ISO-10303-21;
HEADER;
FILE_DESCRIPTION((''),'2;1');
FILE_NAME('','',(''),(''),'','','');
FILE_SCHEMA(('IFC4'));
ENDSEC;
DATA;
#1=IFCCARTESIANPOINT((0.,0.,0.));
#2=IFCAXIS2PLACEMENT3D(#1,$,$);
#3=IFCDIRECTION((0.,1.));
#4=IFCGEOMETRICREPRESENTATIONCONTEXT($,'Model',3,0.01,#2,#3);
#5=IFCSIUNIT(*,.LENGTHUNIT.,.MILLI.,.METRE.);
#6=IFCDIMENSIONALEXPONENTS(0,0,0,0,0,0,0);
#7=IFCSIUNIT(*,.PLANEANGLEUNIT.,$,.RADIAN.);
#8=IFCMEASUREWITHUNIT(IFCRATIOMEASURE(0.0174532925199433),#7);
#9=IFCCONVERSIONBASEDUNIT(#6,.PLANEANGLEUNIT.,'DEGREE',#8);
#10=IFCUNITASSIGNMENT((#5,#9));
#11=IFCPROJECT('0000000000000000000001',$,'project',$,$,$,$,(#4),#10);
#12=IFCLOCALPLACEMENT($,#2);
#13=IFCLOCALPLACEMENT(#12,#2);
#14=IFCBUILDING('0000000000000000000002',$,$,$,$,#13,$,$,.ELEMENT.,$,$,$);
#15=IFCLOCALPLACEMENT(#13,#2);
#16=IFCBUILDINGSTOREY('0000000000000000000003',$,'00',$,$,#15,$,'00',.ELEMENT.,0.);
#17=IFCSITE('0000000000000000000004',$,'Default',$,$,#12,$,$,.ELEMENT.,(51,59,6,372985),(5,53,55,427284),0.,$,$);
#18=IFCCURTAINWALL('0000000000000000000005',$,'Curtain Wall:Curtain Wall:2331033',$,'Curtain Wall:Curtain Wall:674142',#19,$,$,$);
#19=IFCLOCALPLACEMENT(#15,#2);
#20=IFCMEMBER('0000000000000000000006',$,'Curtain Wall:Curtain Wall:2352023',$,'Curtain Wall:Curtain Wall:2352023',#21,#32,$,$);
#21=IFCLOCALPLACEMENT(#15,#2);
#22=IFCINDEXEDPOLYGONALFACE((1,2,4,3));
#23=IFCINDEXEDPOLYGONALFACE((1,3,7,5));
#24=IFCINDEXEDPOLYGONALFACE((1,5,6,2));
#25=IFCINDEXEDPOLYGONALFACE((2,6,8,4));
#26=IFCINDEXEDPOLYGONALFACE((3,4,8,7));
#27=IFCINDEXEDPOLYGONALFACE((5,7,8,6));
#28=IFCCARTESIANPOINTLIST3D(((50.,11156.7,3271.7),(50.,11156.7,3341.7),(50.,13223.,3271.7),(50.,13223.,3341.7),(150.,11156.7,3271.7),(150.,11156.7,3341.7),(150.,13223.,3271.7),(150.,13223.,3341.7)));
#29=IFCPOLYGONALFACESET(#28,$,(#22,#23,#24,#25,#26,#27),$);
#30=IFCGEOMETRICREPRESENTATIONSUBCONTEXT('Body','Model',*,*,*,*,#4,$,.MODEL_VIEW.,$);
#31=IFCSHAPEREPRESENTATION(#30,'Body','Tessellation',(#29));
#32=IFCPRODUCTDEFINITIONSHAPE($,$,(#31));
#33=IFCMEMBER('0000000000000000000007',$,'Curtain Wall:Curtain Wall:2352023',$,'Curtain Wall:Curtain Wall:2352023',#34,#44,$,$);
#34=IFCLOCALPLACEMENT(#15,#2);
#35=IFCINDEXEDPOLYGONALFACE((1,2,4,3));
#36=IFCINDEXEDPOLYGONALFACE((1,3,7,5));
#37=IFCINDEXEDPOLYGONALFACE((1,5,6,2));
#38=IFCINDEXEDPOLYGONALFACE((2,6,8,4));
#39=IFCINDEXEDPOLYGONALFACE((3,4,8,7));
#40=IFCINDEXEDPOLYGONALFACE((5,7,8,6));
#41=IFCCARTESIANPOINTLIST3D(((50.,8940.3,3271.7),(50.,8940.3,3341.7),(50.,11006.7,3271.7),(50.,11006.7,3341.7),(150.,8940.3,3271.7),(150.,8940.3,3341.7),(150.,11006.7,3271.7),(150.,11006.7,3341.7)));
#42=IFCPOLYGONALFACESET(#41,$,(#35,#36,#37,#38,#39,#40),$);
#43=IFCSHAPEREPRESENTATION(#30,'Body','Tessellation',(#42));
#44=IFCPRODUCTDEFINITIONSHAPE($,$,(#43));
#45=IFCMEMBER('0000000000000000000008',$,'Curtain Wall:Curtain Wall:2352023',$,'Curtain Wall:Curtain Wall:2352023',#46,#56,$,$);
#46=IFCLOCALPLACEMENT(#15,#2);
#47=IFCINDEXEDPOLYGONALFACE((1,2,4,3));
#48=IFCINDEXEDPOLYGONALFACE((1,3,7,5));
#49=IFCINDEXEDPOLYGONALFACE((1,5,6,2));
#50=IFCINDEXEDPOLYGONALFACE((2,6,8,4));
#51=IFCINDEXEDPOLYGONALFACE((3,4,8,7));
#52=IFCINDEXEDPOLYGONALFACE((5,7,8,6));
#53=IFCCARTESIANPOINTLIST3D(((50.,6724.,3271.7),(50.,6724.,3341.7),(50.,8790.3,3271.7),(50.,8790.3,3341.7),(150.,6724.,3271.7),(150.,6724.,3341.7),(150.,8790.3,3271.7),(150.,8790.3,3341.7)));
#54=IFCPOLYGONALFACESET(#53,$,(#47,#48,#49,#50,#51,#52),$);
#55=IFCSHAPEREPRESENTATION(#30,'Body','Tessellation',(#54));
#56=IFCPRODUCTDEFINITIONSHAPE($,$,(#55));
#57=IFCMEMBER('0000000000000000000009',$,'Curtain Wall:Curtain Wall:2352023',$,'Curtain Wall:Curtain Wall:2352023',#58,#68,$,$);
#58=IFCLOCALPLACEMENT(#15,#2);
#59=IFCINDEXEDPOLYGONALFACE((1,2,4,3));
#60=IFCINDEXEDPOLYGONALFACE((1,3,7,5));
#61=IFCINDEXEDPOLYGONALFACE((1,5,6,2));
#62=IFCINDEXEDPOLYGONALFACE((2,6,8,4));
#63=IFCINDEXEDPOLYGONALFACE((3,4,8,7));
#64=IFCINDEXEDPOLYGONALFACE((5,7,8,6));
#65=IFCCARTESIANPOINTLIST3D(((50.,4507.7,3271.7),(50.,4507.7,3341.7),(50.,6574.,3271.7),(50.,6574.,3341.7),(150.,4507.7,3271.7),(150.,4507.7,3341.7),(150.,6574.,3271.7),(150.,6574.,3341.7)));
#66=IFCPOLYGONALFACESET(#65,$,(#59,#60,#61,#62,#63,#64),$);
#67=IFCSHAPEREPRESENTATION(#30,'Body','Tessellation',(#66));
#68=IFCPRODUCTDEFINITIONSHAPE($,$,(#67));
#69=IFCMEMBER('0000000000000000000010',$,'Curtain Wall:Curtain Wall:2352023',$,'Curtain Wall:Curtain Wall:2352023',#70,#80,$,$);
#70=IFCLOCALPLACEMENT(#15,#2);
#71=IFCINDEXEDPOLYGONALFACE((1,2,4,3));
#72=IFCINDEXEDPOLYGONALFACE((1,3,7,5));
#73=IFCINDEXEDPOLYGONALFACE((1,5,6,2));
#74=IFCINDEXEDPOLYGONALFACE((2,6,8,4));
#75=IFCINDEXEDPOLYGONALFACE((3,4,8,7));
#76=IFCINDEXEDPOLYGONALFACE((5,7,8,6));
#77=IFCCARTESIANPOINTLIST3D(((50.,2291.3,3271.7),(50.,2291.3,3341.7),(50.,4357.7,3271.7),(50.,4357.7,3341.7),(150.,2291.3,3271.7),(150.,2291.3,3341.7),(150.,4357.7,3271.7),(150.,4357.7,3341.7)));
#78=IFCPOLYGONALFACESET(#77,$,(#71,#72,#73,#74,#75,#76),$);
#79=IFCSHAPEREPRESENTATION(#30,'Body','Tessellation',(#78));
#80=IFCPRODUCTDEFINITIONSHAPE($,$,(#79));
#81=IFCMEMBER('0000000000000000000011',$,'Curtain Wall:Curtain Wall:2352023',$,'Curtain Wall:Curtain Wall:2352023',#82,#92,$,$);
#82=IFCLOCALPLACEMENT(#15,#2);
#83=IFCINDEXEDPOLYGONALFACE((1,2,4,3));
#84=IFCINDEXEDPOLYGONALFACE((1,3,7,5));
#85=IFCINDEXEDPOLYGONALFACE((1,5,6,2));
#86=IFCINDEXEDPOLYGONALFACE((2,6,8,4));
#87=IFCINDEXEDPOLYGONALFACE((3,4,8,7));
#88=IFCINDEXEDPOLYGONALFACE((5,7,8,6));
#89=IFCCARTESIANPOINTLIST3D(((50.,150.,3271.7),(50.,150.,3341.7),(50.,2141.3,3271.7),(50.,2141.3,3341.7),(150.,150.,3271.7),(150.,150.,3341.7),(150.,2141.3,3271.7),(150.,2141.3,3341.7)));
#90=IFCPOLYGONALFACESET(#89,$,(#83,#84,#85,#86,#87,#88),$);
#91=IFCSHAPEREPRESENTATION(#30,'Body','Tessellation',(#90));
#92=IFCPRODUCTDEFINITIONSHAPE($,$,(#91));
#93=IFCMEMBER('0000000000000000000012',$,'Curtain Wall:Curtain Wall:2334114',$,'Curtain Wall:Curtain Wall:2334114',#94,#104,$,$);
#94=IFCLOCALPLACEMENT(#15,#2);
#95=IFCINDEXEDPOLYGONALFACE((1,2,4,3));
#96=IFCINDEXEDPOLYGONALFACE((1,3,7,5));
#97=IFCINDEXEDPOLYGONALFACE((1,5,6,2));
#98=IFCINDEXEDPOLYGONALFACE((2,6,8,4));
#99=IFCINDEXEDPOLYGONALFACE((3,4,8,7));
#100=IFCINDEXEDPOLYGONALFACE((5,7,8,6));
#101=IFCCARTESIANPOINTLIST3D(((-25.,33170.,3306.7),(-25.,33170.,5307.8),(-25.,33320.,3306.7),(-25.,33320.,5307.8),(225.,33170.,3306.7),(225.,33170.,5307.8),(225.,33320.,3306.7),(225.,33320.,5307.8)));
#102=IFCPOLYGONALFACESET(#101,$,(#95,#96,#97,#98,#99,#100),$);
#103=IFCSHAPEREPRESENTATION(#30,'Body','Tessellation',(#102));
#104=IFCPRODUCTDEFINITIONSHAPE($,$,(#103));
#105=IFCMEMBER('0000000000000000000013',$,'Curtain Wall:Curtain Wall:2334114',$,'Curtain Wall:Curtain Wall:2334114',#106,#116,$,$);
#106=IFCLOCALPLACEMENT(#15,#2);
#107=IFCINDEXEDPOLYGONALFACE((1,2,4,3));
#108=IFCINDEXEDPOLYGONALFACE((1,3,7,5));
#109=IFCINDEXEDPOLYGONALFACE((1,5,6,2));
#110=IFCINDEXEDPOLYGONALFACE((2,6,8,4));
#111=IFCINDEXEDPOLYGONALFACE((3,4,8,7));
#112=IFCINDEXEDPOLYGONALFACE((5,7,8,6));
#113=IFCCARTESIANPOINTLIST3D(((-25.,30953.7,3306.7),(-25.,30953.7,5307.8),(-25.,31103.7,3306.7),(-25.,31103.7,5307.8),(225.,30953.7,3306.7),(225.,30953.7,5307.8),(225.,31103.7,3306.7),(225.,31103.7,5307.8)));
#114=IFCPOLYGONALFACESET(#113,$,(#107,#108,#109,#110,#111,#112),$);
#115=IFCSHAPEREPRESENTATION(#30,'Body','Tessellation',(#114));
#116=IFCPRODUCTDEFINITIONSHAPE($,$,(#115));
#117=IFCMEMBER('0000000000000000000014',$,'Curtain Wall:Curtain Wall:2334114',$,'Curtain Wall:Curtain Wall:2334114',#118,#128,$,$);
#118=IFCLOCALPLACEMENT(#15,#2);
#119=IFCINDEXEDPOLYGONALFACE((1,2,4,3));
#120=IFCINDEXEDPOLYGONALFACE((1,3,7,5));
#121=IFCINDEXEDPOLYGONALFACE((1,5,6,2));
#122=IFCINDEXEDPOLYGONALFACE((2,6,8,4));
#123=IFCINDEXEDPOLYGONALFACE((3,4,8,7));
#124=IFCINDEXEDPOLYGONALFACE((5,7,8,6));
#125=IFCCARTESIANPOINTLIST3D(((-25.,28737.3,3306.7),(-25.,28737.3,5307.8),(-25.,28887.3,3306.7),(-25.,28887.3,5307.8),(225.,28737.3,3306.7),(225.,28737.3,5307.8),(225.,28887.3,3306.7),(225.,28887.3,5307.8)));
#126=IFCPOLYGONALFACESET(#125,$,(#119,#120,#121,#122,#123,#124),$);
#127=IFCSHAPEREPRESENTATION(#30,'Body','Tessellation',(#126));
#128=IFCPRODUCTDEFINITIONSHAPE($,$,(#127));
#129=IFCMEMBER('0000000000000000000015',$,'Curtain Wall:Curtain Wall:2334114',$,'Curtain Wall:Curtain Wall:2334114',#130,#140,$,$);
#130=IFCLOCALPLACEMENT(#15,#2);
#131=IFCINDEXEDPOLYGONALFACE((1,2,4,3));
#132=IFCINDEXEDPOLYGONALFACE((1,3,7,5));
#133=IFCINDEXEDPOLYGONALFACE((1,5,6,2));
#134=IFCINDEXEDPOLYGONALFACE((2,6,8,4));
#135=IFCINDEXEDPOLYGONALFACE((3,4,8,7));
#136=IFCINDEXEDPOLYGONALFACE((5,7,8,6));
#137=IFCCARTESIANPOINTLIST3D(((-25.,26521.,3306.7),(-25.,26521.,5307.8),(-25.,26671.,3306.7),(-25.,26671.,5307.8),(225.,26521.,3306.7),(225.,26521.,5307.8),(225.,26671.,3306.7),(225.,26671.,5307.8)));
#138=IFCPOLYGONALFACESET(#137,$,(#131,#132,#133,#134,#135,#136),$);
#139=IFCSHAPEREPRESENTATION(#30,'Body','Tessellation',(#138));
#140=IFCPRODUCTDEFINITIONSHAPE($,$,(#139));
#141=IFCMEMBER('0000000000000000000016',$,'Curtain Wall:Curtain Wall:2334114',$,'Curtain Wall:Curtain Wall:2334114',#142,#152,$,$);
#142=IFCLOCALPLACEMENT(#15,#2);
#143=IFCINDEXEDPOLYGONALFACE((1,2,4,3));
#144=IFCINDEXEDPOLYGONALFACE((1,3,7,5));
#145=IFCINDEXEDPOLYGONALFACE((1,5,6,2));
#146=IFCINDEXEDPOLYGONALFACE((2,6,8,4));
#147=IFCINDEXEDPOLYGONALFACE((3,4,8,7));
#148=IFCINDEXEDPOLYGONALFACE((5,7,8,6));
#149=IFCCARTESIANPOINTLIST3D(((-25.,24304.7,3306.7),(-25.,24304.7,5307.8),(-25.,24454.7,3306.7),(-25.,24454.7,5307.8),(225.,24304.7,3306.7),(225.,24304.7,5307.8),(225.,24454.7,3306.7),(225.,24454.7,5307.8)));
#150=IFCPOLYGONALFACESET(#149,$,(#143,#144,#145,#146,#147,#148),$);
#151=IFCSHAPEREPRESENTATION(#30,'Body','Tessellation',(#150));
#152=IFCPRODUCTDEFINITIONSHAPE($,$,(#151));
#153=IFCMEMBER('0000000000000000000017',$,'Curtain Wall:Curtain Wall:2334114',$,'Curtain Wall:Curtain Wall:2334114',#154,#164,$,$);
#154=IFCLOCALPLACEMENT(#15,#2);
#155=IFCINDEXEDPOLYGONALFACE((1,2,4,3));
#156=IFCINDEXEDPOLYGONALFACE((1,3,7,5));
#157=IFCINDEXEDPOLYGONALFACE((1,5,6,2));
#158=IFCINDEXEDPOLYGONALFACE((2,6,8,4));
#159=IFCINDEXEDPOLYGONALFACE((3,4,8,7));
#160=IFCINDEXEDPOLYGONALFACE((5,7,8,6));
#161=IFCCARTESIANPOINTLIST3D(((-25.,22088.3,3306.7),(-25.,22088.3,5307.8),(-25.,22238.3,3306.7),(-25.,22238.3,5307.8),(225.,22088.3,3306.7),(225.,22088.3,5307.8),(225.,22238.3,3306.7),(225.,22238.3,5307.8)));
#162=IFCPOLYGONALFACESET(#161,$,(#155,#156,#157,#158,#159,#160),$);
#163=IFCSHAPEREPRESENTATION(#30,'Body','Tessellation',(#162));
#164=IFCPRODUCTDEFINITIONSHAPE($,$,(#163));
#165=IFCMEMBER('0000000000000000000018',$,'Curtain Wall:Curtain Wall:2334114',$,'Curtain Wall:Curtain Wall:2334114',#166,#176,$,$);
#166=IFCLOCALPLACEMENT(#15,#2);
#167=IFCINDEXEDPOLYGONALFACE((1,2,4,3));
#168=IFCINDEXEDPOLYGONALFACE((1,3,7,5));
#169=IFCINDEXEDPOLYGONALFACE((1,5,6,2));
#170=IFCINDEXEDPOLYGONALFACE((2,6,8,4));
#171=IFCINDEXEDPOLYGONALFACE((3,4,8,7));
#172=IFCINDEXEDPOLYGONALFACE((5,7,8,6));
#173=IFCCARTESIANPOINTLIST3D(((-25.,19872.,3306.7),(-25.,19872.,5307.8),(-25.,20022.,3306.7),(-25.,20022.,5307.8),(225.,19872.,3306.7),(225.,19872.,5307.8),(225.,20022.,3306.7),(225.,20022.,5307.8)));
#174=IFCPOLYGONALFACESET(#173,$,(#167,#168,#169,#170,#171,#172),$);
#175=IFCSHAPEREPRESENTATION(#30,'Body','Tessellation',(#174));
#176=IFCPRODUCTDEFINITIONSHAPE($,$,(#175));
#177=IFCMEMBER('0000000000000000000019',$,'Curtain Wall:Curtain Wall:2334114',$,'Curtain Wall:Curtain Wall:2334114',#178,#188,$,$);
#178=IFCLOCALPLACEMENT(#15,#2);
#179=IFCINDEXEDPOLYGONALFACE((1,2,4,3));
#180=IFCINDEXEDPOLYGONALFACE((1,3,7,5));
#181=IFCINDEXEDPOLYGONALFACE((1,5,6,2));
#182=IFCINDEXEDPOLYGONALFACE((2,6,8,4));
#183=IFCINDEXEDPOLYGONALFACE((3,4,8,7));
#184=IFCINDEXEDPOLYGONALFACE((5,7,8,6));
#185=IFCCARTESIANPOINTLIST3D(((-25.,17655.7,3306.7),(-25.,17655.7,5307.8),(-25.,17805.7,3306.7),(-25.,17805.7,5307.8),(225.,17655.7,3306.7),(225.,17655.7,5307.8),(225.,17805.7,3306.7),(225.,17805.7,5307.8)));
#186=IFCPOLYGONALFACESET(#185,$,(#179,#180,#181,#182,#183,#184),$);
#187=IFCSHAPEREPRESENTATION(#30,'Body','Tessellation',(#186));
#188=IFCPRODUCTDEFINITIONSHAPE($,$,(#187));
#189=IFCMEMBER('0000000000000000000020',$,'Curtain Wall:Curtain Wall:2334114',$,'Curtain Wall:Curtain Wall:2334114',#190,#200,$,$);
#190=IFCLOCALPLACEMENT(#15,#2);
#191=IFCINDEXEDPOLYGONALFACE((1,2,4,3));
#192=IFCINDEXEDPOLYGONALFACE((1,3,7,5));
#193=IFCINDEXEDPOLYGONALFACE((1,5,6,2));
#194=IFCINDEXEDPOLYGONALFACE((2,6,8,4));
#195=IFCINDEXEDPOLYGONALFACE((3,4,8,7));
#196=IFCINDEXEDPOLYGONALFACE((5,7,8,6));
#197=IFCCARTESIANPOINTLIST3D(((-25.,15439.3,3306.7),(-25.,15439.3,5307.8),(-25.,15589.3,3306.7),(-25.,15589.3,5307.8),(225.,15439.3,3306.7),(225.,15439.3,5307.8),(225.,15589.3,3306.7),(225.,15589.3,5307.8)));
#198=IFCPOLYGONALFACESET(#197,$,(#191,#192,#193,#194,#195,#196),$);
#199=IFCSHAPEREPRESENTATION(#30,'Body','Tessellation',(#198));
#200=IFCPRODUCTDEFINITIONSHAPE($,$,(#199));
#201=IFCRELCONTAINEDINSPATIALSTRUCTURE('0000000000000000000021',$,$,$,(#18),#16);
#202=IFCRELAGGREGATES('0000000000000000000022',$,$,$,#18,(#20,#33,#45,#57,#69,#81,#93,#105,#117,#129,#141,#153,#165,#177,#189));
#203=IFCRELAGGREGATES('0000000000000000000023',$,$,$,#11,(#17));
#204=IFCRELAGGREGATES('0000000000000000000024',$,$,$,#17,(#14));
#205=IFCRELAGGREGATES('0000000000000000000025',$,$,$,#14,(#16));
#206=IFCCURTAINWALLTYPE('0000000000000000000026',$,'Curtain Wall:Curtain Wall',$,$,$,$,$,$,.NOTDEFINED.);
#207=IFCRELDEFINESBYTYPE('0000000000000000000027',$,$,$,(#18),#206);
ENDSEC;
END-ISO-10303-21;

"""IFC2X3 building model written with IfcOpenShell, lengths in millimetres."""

from ifc_helpers import new_model, entity, si_unit, converted_unit, direction, frame, frame_2d, origin, origin_2d_with_axis, place, context, subcontext, project, spatial, rectangle, extrude, type_object, element, aggregate, save


model = new_model("IFC2X3")

# Units and contexts
model_context = context("Model", 3, precision=0.01, world=origin(), true_north=direction((0.0, 1.0)))
body_context = subcontext(model_context, "Body", "Model", "MODEL_VIEW")
ifc_project = project(units=[si_unit("LENGTHUNIT", "METRE", prefix="MILLI"), converted_unit("PLANEANGLEUNIT", "DEGREE", entity("IfcRatioMeasure", 0.0174532925199433), si_unit("PLANEANGLEUNIT", "RADIAN"), dimensions=[0, 0, 0, 0, 0, 0, 0])], contexts=[model_context])

# Site, building, storey
site_placement = place(None, origin())
site = spatial("IfcSite", under=ifc_project, at=site_placement, Name="Default", CompositionType="ELEMENT", RefLatitude=(51, 59, 6, 372985), RefLongitude=(5, 53, 55, 427284), RefElevation=0.0)
building_placement = place(site_placement, origin())
building = spatial("IfcBuilding", under=site, at=building_placement, CompositionType="ELEMENT")
storey_placement = place(building_placement, origin())
storey = spatial("IfcBuildingStorey", under=building, at=storey_placement, Name="00", LongName="00", CompositionType="ELEMENT", Elevation=0.0)

# Curtain wall, members
curtain_wall_type = type_object("IfcCurtainWallType", Name="Curtain Wall:Curtain Wall", PredefinedType="NOTDEFINED")
curtain_wall_placement = place(storey_placement, origin())
curtain_wall = element("IfcCurtainWall", 1, at=curtain_wall_placement, inside=storey, type_object=curtain_wall_type, Name="Curtain Wall:Curtain Wall:2331033", ObjectType="Curtain Wall:Curtain Wall:674142")
member_1_placement = place(curtain_wall_placement, origin())
member_1 = element("IfcMember", 2, at=member_1_placement, Name="Curtain Wall:Curtain Wall:2352023", ObjectType="Curtain Wall:Curtain Wall:2352023", context=body_context, shape_type="SweptSolid", body=[
    extrude(rectangle(XDim=70.0, YDim=100.0, at=frame_2d((0.0, 0.0), x_axis=(1.0, 0.0))), frame((100.0, 11156.7, 3306.7), z_axis=(0.0, 1.0, 0.0), x_axis=(0.0, 0.0, -1.0)), (0.0, 0.0, 1.0), 2066.3),
])
member_2_placement = place(curtain_wall_placement, origin())
member_2 = element("IfcMember", 3, at=member_2_placement, Name="Curtain Wall:Curtain Wall:2352023", ObjectType="Curtain Wall:Curtain Wall:2352023", context=body_context, shape_type="SweptSolid", body=[
    extrude(rectangle(XDim=70.0, YDim=100.0, at=frame_2d((0.0, 0.0), x_axis=(1.0, 0.0))), frame((100.0, 8940.3, 3306.7), z_axis=(0.0, 1.0, 0.0), x_axis=(0.0, 0.0, -1.0)), (0.0, 0.0, 1.0), 2066.3),
])
member_3_placement = place(curtain_wall_placement, origin())
member_3 = element("IfcMember", 4, at=member_3_placement, Name="Curtain Wall:Curtain Wall:2352023", ObjectType="Curtain Wall:Curtain Wall:2352023", context=body_context, shape_type="SweptSolid", body=[
    extrude(rectangle(XDim=70.0, YDim=100.0, at=frame_2d((0.0, 0.0), x_axis=(1.0, 0.0))), frame((100.0, 6724.0, 3306.7), z_axis=(0.0, 1.0, 0.0), x_axis=(0.0, 0.0, -1.0)), (0.0, 0.0, 1.0), 2066.3),
])
member_4_placement = place(curtain_wall_placement, origin())
member_4 = element("IfcMember", 5, at=member_4_placement, Name="Curtain Wall:Curtain Wall:2352023", ObjectType="Curtain Wall:Curtain Wall:2352023", context=body_context, shape_type="SweptSolid", body=[
    extrude(rectangle(XDim=70.0, YDim=100.0, at=frame_2d((0.0, 0.0), x_axis=(1.0, 0.0))), frame((100.0, 4507.7, 3306.7), z_axis=(0.0, 1.0, 0.0), x_axis=(0.0, 0.0, -1.0)), (0.0, 0.0, 1.0), 2066.3),
])
member_5_placement = place(curtain_wall_placement, origin())
member_5 = element("IfcMember", 6, at=member_5_placement, Name="Curtain Wall:Curtain Wall:2352023", ObjectType="Curtain Wall:Curtain Wall:2352023", context=body_context, shape_type="SweptSolid", body=[
    extrude(rectangle(XDim=70.0, YDim=100.0, at=frame_2d((0.0, 0.0), x_axis=(1.0, 0.0))), frame((100.0, 2291.3, 3306.7), z_axis=(0.0, 1.0, 0.0), x_axis=(0.0, 0.0, -1.0)), (0.0, 0.0, 1.0), 2066.3),
])
member_6_placement = place(curtain_wall_placement, origin())
member_6 = element("IfcMember", 7, at=member_6_placement, Name="Curtain Wall:Curtain Wall:2352023", ObjectType="Curtain Wall:Curtain Wall:2352023", context=body_context, shape_type="SweptSolid", body=[
    extrude(rectangle(XDim=70.0, YDim=100.0, at=frame_2d((0.0, 0.0), x_axis=(1.0, 0.0))), frame((100.0, 150.0, 3306.7), z_axis=(0.0, 1.0, 0.0), x_axis=(0.0, 0.0, -1.0)), (0.0, 0.0, 1.0), 1991.3),
])
member_7_placement = place(curtain_wall_placement, origin())
member_7 = element("IfcMember", 8, at=member_7_placement, Name="Curtain Wall:Curtain Wall:2334114", ObjectType="Curtain Wall:Curtain Wall:2334114", context=body_context, shape_type="SweptSolid", body=[
    extrude(rectangle(XDim=250.0, YDim=150.0, at=origin_2d_with_axis()), frame((100.0, 33245.0, 3306.7), z_axis=(0.0, 0.0, 1.0), x_axis=(-1.0, 0.0, 0.0)), (0.0, 0.0, 1.0), 2001.1),
])
member_8_placement = place(curtain_wall_placement, origin())
member_8 = element("IfcMember", 9, at=member_8_placement, Name="Curtain Wall:Curtain Wall:2334114", ObjectType="Curtain Wall:Curtain Wall:2334114", context=body_context, shape_type="SweptSolid", body=[
    extrude(rectangle(XDim=250.0, YDim=150.0, at=frame_2d((0.0, 0.0), x_axis=(1.0, 0.0))), frame((100.0, 31028.7, 3306.7), z_axis=(0.0, 0.0, 1.0), x_axis=(-1.0, 0.0, 0.0)), (0.0, 0.0, 1.0), 2001.1),
])
member_9_placement = place(curtain_wall_placement, origin())
member_9 = element("IfcMember", 10, at=member_9_placement, Name="Curtain Wall:Curtain Wall:2334114", ObjectType="Curtain Wall:Curtain Wall:2334114", context=body_context, shape_type="SweptSolid", body=[
    extrude(rectangle(XDim=250.0, YDim=150.0, at=frame_2d((0.0, 0.0), x_axis=(1.0, 0.0))), frame((100.0, 28812.3, 3306.7), z_axis=(0.0, 0.0, 1.0), x_axis=(-1.0, 0.0, 0.0)), (0.0, 0.0, 1.0), 2001.1),
])
member_10_placement = place(curtain_wall_placement, origin())
member_10 = element("IfcMember", 11, at=member_10_placement, Name="Curtain Wall:Curtain Wall:2334114", ObjectType="Curtain Wall:Curtain Wall:2334114", context=body_context, shape_type="SweptSolid", body=[
    extrude(rectangle(XDim=250.0, YDim=150.0, at=frame_2d((0.0, 0.0), x_axis=(1.0, 0.0))), frame((100.0, 26596.0, 3306.7), z_axis=(0.0, 0.0, 1.0), x_axis=(-1.0, 0.0, 0.0)), (0.0, 0.0, 1.0), 2001.1),
])
member_11_placement = place(curtain_wall_placement, origin())
member_11 = element("IfcMember", 12, at=member_11_placement, Name="Curtain Wall:Curtain Wall:2334114", ObjectType="Curtain Wall:Curtain Wall:2334114", context=body_context, shape_type="SweptSolid", body=[
    extrude(rectangle(XDim=250.0, YDim=150.0, at=origin_2d_with_axis()), frame((100.0, 24379.7, 3306.7), z_axis=(0.0, 0.0, 1.0), x_axis=(-1.0, 0.0, 0.0)), (0.0, 0.0, 1.0), 2001.1),
])
member_12_placement = place(curtain_wall_placement, origin())
member_12 = element("IfcMember", 13, at=member_12_placement, Name="Curtain Wall:Curtain Wall:2334114", ObjectType="Curtain Wall:Curtain Wall:2334114", context=body_context, shape_type="SweptSolid", body=[
    extrude(rectangle(XDim=250.0, YDim=150.0, at=origin_2d_with_axis()), frame((100.0, 22163.3, 3306.7), z_axis=(0.0, 0.0, 1.0), x_axis=(-1.0, 0.0, 0.0)), (0.0, 0.0, 1.0), 2001.1),
])
member_13_placement = place(curtain_wall_placement, origin())
member_13 = element("IfcMember", 14, at=member_13_placement, Name="Curtain Wall:Curtain Wall:2334114", ObjectType="Curtain Wall:Curtain Wall:2334114", context=body_context, shape_type="SweptSolid", body=[
    extrude(rectangle(XDim=250.0, YDim=150.0, at=frame_2d((0.0, 0.0), x_axis=(1.0, 0.0))), frame((100.0, 19947.0, 3306.7), z_axis=(0.0, 0.0, 1.0), x_axis=(-1.0, 0.0, 0.0)), (0.0, 0.0, 1.0), 2001.1),
])
member_14_placement = place(curtain_wall_placement, origin())
member_14 = element("IfcMember", 15, at=member_14_placement, Name="Curtain Wall:Curtain Wall:2334114", ObjectType="Curtain Wall:Curtain Wall:2334114", context=body_context, shape_type="SweptSolid", body=[
    extrude(rectangle(XDim=250.0, YDim=150.0, at=frame_2d((0.0, 0.0), x_axis=(1.0, 0.0))), frame((100.0, 17730.7, 3306.7), z_axis=(0.0, 0.0, 1.0), x_axis=(-1.0, 0.0, 0.0)), (0.0, 0.0, 1.0), 2001.1),
])
member_15_placement = place(curtain_wall_placement, origin())
member_15 = element("IfcMember", 16, at=member_15_placement, Name="Curtain Wall:Curtain Wall:2334114", ObjectType="Curtain Wall:Curtain Wall:2334114", context=body_context, shape_type="SweptSolid", body=[
    extrude(rectangle(XDim=250.0, YDim=150.0, at=frame_2d((0.0, 0.0), x_axis=(1.0, 0.0))), frame((100.0, 15514.3, 3306.7), z_axis=(0.0, 0.0, 1.0), x_axis=(-1.0, 0.0, 0.0)), (0.0, 0.0, 1.0), 2001.1),
])
aggregate(curtain_wall, [member_1, member_2, member_3, member_4, member_5, member_6, member_7, member_8, member_9, member_10, member_11, member_12, member_13, member_14, member_15])

save(model, "model.ifc")
